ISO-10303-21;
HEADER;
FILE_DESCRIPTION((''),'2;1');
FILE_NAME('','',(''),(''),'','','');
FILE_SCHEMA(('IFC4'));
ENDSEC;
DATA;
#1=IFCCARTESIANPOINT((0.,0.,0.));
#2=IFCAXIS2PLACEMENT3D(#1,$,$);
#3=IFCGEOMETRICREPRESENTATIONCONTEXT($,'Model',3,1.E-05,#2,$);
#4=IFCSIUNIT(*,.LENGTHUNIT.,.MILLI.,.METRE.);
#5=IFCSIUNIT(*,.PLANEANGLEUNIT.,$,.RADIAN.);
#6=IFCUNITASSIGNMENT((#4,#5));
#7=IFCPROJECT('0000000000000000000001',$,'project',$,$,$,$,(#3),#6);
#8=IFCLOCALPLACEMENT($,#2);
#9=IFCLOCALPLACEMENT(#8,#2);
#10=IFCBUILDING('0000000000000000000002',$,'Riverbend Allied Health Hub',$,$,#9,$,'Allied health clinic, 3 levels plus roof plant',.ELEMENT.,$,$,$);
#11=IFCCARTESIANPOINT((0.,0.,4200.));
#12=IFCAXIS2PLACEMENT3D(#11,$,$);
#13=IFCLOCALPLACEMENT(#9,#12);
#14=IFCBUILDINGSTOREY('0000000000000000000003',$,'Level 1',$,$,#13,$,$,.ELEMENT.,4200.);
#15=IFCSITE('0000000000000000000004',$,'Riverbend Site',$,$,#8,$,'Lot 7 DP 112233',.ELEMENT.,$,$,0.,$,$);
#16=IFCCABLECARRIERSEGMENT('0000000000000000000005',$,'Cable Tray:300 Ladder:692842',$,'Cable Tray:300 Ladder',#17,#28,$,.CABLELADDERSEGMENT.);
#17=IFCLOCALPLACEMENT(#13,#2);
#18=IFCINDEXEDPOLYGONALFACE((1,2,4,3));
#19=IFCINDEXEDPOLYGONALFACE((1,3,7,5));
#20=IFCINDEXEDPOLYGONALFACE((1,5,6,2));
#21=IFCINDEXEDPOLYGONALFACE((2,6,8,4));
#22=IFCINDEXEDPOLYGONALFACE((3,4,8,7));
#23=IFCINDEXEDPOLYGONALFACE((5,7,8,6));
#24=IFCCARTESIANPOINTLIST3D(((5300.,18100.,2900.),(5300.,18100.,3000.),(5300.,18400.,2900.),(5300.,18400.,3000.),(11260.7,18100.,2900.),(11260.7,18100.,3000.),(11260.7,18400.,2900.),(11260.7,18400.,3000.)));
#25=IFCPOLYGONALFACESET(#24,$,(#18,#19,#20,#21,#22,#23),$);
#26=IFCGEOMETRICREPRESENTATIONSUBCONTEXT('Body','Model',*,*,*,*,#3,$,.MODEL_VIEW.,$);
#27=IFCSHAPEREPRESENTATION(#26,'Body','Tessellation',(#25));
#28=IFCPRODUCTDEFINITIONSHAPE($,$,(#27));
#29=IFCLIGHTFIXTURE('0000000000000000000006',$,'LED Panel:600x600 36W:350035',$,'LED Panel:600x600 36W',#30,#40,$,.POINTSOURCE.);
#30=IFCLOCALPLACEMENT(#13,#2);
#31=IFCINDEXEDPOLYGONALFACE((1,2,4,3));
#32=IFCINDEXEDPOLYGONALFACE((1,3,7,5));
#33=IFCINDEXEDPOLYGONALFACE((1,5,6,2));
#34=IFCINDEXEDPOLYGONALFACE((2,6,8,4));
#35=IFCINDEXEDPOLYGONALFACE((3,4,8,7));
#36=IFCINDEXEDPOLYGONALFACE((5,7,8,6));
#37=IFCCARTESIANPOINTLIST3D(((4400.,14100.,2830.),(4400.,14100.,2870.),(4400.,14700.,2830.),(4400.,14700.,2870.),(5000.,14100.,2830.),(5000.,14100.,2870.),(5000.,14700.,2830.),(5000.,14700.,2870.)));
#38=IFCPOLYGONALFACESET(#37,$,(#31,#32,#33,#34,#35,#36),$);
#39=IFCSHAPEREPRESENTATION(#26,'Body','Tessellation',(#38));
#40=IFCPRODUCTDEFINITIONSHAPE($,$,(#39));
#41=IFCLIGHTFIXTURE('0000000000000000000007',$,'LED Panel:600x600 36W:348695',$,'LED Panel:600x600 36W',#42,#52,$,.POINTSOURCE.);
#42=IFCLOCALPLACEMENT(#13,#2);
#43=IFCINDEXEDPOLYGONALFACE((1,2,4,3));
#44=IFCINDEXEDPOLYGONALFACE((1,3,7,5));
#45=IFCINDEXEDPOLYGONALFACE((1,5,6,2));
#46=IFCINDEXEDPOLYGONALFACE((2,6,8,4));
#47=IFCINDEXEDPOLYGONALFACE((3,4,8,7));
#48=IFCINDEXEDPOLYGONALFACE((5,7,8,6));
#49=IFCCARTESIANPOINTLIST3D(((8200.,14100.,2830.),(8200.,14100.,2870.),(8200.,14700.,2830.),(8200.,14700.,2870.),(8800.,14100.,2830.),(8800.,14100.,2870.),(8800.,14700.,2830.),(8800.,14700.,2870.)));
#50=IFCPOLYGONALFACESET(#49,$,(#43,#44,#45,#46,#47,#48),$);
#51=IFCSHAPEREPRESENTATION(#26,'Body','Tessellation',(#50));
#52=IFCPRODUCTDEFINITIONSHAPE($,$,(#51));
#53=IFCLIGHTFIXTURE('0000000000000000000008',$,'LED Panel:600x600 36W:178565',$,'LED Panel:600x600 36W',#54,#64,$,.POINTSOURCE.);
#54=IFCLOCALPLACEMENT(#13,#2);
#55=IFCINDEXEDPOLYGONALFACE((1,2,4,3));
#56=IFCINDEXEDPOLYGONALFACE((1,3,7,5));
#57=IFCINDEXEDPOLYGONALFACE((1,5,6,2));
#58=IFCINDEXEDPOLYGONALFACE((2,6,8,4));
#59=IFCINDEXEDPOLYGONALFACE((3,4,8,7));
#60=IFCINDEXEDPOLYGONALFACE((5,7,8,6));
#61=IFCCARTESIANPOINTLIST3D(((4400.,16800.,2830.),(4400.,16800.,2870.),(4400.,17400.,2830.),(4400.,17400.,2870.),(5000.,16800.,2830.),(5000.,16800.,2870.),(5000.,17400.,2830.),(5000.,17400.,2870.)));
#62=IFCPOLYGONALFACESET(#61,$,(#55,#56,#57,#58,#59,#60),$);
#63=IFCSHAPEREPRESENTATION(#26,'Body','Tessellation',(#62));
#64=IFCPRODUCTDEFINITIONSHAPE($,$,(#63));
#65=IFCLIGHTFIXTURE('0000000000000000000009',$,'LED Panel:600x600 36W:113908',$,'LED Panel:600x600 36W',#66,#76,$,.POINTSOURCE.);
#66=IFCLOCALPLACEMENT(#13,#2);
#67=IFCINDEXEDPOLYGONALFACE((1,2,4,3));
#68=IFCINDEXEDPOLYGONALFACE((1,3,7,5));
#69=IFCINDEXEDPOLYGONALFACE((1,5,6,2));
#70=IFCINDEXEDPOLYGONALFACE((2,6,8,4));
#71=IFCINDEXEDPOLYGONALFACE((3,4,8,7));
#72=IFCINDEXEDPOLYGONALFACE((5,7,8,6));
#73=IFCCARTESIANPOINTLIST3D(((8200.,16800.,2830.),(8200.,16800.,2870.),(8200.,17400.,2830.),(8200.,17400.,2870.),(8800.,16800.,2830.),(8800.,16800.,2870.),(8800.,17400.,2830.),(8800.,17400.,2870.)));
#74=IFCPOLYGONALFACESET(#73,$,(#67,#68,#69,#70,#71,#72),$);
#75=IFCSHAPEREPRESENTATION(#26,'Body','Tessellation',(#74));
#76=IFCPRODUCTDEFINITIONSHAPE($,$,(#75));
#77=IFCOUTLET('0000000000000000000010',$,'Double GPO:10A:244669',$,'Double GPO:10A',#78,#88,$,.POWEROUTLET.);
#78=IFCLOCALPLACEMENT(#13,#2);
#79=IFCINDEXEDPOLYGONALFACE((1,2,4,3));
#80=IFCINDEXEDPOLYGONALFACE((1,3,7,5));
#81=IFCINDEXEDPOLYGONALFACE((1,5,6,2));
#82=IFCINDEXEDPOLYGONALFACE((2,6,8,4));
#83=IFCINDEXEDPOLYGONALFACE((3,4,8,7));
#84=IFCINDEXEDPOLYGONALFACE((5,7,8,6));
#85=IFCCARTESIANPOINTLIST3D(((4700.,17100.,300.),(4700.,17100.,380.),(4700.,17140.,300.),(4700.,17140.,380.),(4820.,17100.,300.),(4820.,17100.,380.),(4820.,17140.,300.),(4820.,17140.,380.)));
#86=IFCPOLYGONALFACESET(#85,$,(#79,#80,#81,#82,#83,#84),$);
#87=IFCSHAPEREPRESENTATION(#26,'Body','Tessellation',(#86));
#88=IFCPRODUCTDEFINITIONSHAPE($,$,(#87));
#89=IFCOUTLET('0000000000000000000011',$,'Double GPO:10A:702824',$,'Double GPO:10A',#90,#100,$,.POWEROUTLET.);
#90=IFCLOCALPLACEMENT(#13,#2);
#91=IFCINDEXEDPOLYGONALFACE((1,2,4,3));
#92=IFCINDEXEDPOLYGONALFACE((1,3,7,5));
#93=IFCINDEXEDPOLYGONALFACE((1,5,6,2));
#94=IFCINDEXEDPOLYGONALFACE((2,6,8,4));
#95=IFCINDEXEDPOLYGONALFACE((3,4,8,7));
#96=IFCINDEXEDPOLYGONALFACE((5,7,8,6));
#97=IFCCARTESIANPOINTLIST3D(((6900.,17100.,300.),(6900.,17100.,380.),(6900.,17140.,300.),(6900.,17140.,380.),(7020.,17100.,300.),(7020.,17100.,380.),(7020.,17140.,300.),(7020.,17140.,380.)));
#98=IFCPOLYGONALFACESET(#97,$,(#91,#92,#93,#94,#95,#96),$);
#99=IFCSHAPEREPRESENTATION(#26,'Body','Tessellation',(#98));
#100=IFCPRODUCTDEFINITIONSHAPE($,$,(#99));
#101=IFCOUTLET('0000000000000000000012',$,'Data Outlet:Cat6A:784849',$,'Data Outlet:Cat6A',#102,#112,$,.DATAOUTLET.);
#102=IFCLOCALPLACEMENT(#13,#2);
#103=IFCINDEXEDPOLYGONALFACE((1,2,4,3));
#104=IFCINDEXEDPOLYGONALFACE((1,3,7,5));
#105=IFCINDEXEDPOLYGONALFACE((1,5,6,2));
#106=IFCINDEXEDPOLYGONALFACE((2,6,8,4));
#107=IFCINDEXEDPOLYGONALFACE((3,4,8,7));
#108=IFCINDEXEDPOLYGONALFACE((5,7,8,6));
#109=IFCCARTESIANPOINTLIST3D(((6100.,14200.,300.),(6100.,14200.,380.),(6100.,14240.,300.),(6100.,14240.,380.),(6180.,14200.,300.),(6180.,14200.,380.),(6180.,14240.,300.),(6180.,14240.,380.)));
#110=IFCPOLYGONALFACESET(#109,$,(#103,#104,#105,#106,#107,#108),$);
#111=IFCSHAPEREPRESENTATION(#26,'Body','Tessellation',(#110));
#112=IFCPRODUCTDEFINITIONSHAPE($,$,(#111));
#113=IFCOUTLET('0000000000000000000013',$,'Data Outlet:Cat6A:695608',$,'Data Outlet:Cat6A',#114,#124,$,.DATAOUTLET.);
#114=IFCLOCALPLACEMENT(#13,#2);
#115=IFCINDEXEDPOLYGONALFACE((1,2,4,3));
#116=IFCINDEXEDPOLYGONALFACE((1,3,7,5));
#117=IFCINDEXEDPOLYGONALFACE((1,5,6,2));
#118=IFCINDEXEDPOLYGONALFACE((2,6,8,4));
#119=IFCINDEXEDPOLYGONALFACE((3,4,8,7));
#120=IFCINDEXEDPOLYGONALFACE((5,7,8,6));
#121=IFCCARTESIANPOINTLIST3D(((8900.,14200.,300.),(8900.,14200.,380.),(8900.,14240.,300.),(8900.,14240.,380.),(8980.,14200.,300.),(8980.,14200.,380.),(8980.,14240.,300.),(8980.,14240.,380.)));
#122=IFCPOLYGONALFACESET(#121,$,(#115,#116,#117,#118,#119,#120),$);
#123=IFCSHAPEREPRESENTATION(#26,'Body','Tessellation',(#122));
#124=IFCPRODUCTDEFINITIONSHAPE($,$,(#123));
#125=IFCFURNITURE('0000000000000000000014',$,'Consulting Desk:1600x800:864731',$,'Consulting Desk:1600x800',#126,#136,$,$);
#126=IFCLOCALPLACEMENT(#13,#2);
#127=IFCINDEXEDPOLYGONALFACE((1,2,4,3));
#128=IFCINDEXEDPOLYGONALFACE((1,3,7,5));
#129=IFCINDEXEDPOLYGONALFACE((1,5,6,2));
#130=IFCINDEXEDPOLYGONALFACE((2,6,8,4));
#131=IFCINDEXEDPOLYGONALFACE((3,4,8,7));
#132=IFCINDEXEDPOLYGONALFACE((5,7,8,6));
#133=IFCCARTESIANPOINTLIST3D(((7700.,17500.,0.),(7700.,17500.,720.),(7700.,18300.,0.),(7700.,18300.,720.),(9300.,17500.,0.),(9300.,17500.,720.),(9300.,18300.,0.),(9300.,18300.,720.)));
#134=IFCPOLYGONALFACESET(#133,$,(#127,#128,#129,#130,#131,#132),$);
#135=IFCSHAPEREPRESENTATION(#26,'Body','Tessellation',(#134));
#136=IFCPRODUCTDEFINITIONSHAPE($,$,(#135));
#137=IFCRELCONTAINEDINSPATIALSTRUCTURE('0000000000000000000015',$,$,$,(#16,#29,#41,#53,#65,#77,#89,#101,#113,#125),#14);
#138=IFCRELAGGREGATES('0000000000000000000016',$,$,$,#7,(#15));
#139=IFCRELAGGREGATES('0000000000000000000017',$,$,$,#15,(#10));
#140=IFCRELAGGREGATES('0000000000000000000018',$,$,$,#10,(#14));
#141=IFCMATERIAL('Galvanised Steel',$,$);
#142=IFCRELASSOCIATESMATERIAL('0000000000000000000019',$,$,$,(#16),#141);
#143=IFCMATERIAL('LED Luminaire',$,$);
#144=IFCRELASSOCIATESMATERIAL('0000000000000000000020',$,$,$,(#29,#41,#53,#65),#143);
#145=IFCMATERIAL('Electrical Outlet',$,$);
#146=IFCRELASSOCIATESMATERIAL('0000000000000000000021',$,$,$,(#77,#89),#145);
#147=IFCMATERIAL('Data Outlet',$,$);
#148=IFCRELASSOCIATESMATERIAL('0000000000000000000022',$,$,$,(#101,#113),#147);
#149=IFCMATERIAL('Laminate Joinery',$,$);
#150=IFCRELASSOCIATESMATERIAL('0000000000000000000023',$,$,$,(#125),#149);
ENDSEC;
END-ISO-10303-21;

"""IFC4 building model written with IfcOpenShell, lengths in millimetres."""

from ifc_helpers import new_model, si_unit, frame, frame_2d, origin, place, context, subcontext, project, spatial, rectangle, extrude, material, element, save


model = new_model("IFC4")

# Units and contexts
model_context = context("Model", 3, precision=1e-05, world=origin())
body_context = subcontext(model_context, "Body", "Model", "MODEL_VIEW")
ifc_project = project(units=[si_unit("LENGTHUNIT", "METRE", prefix="MILLI"), si_unit("PLANEANGLEUNIT", "RADIAN")], contexts=[model_context])

# Site, building, storey
site_placement = place(None, origin())
site = spatial("IfcSite", under=ifc_project, at=site_placement, Name="Riverbend Site", LongName="Lot 7 DP 112233", CompositionType="ELEMENT", RefElevation=0.0)
building_placement = place(site_placement, origin())
building = spatial("IfcBuilding", under=site, at=building_placement, Name="Riverbend Allied Health Hub", LongName="Allied health clinic, 3 levels plus roof plant", CompositionType="ELEMENT")
storey_placement = place(building_placement, frame((0.0, 0.0, 4200.0)))
storey = spatial("IfcBuildingStorey", under=building, at=storey_placement, Name="Level 1", CompositionType="ELEMENT", Elevation=4200.0)

# Shared definitions
ifc_material_1 = material(Name="Galvanised Steel")

# Cable carrier segment
cable_carrier_segment_1_placement = place(storey_placement, frame((5300.0, 18100.0, 2900.0)))
element("IfcCableCarrierSegment", 1, at=cable_carrier_segment_1_placement, inside=storey, material=ifc_material_1, Name="Cable Tray:300 Ladder:692842", ObjectType="Cable Tray:300 Ladder", PredefinedType="CABLELADDERSEGMENT", context=body_context, shape_type="SweptSolid", body=[
    extrude(rectangle(XDim=5960.7, YDim=300.0, at=frame_2d((2980.4, 150.0))), origin(), (0.0, 0.0, 1.0), 100.0),
])

# Light fixtures
ifc_material_2 = material(Name="LED Luminaire")
for number, where, name in (
    (2, (4400.0, 14100.0, 2830.0), "LED Panel:600x600 36W:350035"),
    (3, (8200.0, 14100.0, 2830.0), "LED Panel:600x600 36W:348695"),
    (4, (4400.0, 16800.0, 2830.0), "LED Panel:600x600 36W:178565"),
    (5, (8200.0, 16800.0, 2830.0), "LED Panel:600x600 36W:113908"),
):
    element("IfcLightFixture", number, at=place(storey_placement, frame(where)), inside=storey, material=ifc_material_2, Name=name, ObjectType="LED Panel:600x600 36W", PredefinedType="POINTSOURCE", context=body_context, shape_type="SweptSolid", body=[
        extrude(rectangle(XDim=600.0, YDim=600.0, at=frame_2d((300.0, 300.0))), origin(), (0.0, 0.0, 1.0), 40.0),
    ])

# Outlets
ifc_material_3 = material(Name="Electrical Outlet")
for number, where, name in (
    (6, (4700.0, 17100.0, 300.0), "Double GPO:10A:244669"),
    (7, (6900.0, 17100.0, 300.0), "Double GPO:10A:702824"),
):
    element("IfcOutlet", number, at=place(storey_placement, frame(where)), inside=storey, material=ifc_material_3, Name=name, ObjectType="Double GPO:10A", PredefinedType="POWEROUTLET", context=body_context, shape_type="SweptSolid", body=[
        extrude(rectangle(XDim=120.0, YDim=40.0, at=frame_2d((60.0, 20.0))), origin(), (0.0, 0.0, 1.0), 80.0),
    ])
ifc_material_4 = material(Name="Data Outlet")
for number, where, name in (
    (8, (6100.0, 14200.0, 300.0), "Data Outlet:Cat6A:784849"),
    (9, (8900.0, 14200.0, 300.0), "Data Outlet:Cat6A:695608"),
):
    element("IfcOutlet", number, at=place(storey_placement, frame(where)), inside=storey, material=ifc_material_4, Name=name, ObjectType="Data Outlet:Cat6A", PredefinedType="DATAOUTLET", context=body_context, shape_type="SweptSolid", body=[
        extrude(rectangle(XDim=80.0, YDim=40.0, at=frame_2d((40.0, 20.0))), origin(), (0.0, 0.0, 1.0), 80.0),
    ])

# Furniture
ifc_material_5 = material(Name="Laminate Joinery")
furniture_placement = place(storey_placement, frame((7700.0, 17500.0, 0.0)))
element("IfcFurniture", 10, at=furniture_placement, inside=storey, material=ifc_material_5, Name="Consulting Desk:1600x800:864731", ObjectType="Consulting Desk:1600x800", context=body_context, shape_type="SweptSolid", body=[
    extrude(rectangle(XDim=1600.0, YDim=800.0, at=frame_2d((800.0, 400.0))), origin(), (0.0, 0.0, 1.0), 720.0),
])

save(model, "model.ifc")
